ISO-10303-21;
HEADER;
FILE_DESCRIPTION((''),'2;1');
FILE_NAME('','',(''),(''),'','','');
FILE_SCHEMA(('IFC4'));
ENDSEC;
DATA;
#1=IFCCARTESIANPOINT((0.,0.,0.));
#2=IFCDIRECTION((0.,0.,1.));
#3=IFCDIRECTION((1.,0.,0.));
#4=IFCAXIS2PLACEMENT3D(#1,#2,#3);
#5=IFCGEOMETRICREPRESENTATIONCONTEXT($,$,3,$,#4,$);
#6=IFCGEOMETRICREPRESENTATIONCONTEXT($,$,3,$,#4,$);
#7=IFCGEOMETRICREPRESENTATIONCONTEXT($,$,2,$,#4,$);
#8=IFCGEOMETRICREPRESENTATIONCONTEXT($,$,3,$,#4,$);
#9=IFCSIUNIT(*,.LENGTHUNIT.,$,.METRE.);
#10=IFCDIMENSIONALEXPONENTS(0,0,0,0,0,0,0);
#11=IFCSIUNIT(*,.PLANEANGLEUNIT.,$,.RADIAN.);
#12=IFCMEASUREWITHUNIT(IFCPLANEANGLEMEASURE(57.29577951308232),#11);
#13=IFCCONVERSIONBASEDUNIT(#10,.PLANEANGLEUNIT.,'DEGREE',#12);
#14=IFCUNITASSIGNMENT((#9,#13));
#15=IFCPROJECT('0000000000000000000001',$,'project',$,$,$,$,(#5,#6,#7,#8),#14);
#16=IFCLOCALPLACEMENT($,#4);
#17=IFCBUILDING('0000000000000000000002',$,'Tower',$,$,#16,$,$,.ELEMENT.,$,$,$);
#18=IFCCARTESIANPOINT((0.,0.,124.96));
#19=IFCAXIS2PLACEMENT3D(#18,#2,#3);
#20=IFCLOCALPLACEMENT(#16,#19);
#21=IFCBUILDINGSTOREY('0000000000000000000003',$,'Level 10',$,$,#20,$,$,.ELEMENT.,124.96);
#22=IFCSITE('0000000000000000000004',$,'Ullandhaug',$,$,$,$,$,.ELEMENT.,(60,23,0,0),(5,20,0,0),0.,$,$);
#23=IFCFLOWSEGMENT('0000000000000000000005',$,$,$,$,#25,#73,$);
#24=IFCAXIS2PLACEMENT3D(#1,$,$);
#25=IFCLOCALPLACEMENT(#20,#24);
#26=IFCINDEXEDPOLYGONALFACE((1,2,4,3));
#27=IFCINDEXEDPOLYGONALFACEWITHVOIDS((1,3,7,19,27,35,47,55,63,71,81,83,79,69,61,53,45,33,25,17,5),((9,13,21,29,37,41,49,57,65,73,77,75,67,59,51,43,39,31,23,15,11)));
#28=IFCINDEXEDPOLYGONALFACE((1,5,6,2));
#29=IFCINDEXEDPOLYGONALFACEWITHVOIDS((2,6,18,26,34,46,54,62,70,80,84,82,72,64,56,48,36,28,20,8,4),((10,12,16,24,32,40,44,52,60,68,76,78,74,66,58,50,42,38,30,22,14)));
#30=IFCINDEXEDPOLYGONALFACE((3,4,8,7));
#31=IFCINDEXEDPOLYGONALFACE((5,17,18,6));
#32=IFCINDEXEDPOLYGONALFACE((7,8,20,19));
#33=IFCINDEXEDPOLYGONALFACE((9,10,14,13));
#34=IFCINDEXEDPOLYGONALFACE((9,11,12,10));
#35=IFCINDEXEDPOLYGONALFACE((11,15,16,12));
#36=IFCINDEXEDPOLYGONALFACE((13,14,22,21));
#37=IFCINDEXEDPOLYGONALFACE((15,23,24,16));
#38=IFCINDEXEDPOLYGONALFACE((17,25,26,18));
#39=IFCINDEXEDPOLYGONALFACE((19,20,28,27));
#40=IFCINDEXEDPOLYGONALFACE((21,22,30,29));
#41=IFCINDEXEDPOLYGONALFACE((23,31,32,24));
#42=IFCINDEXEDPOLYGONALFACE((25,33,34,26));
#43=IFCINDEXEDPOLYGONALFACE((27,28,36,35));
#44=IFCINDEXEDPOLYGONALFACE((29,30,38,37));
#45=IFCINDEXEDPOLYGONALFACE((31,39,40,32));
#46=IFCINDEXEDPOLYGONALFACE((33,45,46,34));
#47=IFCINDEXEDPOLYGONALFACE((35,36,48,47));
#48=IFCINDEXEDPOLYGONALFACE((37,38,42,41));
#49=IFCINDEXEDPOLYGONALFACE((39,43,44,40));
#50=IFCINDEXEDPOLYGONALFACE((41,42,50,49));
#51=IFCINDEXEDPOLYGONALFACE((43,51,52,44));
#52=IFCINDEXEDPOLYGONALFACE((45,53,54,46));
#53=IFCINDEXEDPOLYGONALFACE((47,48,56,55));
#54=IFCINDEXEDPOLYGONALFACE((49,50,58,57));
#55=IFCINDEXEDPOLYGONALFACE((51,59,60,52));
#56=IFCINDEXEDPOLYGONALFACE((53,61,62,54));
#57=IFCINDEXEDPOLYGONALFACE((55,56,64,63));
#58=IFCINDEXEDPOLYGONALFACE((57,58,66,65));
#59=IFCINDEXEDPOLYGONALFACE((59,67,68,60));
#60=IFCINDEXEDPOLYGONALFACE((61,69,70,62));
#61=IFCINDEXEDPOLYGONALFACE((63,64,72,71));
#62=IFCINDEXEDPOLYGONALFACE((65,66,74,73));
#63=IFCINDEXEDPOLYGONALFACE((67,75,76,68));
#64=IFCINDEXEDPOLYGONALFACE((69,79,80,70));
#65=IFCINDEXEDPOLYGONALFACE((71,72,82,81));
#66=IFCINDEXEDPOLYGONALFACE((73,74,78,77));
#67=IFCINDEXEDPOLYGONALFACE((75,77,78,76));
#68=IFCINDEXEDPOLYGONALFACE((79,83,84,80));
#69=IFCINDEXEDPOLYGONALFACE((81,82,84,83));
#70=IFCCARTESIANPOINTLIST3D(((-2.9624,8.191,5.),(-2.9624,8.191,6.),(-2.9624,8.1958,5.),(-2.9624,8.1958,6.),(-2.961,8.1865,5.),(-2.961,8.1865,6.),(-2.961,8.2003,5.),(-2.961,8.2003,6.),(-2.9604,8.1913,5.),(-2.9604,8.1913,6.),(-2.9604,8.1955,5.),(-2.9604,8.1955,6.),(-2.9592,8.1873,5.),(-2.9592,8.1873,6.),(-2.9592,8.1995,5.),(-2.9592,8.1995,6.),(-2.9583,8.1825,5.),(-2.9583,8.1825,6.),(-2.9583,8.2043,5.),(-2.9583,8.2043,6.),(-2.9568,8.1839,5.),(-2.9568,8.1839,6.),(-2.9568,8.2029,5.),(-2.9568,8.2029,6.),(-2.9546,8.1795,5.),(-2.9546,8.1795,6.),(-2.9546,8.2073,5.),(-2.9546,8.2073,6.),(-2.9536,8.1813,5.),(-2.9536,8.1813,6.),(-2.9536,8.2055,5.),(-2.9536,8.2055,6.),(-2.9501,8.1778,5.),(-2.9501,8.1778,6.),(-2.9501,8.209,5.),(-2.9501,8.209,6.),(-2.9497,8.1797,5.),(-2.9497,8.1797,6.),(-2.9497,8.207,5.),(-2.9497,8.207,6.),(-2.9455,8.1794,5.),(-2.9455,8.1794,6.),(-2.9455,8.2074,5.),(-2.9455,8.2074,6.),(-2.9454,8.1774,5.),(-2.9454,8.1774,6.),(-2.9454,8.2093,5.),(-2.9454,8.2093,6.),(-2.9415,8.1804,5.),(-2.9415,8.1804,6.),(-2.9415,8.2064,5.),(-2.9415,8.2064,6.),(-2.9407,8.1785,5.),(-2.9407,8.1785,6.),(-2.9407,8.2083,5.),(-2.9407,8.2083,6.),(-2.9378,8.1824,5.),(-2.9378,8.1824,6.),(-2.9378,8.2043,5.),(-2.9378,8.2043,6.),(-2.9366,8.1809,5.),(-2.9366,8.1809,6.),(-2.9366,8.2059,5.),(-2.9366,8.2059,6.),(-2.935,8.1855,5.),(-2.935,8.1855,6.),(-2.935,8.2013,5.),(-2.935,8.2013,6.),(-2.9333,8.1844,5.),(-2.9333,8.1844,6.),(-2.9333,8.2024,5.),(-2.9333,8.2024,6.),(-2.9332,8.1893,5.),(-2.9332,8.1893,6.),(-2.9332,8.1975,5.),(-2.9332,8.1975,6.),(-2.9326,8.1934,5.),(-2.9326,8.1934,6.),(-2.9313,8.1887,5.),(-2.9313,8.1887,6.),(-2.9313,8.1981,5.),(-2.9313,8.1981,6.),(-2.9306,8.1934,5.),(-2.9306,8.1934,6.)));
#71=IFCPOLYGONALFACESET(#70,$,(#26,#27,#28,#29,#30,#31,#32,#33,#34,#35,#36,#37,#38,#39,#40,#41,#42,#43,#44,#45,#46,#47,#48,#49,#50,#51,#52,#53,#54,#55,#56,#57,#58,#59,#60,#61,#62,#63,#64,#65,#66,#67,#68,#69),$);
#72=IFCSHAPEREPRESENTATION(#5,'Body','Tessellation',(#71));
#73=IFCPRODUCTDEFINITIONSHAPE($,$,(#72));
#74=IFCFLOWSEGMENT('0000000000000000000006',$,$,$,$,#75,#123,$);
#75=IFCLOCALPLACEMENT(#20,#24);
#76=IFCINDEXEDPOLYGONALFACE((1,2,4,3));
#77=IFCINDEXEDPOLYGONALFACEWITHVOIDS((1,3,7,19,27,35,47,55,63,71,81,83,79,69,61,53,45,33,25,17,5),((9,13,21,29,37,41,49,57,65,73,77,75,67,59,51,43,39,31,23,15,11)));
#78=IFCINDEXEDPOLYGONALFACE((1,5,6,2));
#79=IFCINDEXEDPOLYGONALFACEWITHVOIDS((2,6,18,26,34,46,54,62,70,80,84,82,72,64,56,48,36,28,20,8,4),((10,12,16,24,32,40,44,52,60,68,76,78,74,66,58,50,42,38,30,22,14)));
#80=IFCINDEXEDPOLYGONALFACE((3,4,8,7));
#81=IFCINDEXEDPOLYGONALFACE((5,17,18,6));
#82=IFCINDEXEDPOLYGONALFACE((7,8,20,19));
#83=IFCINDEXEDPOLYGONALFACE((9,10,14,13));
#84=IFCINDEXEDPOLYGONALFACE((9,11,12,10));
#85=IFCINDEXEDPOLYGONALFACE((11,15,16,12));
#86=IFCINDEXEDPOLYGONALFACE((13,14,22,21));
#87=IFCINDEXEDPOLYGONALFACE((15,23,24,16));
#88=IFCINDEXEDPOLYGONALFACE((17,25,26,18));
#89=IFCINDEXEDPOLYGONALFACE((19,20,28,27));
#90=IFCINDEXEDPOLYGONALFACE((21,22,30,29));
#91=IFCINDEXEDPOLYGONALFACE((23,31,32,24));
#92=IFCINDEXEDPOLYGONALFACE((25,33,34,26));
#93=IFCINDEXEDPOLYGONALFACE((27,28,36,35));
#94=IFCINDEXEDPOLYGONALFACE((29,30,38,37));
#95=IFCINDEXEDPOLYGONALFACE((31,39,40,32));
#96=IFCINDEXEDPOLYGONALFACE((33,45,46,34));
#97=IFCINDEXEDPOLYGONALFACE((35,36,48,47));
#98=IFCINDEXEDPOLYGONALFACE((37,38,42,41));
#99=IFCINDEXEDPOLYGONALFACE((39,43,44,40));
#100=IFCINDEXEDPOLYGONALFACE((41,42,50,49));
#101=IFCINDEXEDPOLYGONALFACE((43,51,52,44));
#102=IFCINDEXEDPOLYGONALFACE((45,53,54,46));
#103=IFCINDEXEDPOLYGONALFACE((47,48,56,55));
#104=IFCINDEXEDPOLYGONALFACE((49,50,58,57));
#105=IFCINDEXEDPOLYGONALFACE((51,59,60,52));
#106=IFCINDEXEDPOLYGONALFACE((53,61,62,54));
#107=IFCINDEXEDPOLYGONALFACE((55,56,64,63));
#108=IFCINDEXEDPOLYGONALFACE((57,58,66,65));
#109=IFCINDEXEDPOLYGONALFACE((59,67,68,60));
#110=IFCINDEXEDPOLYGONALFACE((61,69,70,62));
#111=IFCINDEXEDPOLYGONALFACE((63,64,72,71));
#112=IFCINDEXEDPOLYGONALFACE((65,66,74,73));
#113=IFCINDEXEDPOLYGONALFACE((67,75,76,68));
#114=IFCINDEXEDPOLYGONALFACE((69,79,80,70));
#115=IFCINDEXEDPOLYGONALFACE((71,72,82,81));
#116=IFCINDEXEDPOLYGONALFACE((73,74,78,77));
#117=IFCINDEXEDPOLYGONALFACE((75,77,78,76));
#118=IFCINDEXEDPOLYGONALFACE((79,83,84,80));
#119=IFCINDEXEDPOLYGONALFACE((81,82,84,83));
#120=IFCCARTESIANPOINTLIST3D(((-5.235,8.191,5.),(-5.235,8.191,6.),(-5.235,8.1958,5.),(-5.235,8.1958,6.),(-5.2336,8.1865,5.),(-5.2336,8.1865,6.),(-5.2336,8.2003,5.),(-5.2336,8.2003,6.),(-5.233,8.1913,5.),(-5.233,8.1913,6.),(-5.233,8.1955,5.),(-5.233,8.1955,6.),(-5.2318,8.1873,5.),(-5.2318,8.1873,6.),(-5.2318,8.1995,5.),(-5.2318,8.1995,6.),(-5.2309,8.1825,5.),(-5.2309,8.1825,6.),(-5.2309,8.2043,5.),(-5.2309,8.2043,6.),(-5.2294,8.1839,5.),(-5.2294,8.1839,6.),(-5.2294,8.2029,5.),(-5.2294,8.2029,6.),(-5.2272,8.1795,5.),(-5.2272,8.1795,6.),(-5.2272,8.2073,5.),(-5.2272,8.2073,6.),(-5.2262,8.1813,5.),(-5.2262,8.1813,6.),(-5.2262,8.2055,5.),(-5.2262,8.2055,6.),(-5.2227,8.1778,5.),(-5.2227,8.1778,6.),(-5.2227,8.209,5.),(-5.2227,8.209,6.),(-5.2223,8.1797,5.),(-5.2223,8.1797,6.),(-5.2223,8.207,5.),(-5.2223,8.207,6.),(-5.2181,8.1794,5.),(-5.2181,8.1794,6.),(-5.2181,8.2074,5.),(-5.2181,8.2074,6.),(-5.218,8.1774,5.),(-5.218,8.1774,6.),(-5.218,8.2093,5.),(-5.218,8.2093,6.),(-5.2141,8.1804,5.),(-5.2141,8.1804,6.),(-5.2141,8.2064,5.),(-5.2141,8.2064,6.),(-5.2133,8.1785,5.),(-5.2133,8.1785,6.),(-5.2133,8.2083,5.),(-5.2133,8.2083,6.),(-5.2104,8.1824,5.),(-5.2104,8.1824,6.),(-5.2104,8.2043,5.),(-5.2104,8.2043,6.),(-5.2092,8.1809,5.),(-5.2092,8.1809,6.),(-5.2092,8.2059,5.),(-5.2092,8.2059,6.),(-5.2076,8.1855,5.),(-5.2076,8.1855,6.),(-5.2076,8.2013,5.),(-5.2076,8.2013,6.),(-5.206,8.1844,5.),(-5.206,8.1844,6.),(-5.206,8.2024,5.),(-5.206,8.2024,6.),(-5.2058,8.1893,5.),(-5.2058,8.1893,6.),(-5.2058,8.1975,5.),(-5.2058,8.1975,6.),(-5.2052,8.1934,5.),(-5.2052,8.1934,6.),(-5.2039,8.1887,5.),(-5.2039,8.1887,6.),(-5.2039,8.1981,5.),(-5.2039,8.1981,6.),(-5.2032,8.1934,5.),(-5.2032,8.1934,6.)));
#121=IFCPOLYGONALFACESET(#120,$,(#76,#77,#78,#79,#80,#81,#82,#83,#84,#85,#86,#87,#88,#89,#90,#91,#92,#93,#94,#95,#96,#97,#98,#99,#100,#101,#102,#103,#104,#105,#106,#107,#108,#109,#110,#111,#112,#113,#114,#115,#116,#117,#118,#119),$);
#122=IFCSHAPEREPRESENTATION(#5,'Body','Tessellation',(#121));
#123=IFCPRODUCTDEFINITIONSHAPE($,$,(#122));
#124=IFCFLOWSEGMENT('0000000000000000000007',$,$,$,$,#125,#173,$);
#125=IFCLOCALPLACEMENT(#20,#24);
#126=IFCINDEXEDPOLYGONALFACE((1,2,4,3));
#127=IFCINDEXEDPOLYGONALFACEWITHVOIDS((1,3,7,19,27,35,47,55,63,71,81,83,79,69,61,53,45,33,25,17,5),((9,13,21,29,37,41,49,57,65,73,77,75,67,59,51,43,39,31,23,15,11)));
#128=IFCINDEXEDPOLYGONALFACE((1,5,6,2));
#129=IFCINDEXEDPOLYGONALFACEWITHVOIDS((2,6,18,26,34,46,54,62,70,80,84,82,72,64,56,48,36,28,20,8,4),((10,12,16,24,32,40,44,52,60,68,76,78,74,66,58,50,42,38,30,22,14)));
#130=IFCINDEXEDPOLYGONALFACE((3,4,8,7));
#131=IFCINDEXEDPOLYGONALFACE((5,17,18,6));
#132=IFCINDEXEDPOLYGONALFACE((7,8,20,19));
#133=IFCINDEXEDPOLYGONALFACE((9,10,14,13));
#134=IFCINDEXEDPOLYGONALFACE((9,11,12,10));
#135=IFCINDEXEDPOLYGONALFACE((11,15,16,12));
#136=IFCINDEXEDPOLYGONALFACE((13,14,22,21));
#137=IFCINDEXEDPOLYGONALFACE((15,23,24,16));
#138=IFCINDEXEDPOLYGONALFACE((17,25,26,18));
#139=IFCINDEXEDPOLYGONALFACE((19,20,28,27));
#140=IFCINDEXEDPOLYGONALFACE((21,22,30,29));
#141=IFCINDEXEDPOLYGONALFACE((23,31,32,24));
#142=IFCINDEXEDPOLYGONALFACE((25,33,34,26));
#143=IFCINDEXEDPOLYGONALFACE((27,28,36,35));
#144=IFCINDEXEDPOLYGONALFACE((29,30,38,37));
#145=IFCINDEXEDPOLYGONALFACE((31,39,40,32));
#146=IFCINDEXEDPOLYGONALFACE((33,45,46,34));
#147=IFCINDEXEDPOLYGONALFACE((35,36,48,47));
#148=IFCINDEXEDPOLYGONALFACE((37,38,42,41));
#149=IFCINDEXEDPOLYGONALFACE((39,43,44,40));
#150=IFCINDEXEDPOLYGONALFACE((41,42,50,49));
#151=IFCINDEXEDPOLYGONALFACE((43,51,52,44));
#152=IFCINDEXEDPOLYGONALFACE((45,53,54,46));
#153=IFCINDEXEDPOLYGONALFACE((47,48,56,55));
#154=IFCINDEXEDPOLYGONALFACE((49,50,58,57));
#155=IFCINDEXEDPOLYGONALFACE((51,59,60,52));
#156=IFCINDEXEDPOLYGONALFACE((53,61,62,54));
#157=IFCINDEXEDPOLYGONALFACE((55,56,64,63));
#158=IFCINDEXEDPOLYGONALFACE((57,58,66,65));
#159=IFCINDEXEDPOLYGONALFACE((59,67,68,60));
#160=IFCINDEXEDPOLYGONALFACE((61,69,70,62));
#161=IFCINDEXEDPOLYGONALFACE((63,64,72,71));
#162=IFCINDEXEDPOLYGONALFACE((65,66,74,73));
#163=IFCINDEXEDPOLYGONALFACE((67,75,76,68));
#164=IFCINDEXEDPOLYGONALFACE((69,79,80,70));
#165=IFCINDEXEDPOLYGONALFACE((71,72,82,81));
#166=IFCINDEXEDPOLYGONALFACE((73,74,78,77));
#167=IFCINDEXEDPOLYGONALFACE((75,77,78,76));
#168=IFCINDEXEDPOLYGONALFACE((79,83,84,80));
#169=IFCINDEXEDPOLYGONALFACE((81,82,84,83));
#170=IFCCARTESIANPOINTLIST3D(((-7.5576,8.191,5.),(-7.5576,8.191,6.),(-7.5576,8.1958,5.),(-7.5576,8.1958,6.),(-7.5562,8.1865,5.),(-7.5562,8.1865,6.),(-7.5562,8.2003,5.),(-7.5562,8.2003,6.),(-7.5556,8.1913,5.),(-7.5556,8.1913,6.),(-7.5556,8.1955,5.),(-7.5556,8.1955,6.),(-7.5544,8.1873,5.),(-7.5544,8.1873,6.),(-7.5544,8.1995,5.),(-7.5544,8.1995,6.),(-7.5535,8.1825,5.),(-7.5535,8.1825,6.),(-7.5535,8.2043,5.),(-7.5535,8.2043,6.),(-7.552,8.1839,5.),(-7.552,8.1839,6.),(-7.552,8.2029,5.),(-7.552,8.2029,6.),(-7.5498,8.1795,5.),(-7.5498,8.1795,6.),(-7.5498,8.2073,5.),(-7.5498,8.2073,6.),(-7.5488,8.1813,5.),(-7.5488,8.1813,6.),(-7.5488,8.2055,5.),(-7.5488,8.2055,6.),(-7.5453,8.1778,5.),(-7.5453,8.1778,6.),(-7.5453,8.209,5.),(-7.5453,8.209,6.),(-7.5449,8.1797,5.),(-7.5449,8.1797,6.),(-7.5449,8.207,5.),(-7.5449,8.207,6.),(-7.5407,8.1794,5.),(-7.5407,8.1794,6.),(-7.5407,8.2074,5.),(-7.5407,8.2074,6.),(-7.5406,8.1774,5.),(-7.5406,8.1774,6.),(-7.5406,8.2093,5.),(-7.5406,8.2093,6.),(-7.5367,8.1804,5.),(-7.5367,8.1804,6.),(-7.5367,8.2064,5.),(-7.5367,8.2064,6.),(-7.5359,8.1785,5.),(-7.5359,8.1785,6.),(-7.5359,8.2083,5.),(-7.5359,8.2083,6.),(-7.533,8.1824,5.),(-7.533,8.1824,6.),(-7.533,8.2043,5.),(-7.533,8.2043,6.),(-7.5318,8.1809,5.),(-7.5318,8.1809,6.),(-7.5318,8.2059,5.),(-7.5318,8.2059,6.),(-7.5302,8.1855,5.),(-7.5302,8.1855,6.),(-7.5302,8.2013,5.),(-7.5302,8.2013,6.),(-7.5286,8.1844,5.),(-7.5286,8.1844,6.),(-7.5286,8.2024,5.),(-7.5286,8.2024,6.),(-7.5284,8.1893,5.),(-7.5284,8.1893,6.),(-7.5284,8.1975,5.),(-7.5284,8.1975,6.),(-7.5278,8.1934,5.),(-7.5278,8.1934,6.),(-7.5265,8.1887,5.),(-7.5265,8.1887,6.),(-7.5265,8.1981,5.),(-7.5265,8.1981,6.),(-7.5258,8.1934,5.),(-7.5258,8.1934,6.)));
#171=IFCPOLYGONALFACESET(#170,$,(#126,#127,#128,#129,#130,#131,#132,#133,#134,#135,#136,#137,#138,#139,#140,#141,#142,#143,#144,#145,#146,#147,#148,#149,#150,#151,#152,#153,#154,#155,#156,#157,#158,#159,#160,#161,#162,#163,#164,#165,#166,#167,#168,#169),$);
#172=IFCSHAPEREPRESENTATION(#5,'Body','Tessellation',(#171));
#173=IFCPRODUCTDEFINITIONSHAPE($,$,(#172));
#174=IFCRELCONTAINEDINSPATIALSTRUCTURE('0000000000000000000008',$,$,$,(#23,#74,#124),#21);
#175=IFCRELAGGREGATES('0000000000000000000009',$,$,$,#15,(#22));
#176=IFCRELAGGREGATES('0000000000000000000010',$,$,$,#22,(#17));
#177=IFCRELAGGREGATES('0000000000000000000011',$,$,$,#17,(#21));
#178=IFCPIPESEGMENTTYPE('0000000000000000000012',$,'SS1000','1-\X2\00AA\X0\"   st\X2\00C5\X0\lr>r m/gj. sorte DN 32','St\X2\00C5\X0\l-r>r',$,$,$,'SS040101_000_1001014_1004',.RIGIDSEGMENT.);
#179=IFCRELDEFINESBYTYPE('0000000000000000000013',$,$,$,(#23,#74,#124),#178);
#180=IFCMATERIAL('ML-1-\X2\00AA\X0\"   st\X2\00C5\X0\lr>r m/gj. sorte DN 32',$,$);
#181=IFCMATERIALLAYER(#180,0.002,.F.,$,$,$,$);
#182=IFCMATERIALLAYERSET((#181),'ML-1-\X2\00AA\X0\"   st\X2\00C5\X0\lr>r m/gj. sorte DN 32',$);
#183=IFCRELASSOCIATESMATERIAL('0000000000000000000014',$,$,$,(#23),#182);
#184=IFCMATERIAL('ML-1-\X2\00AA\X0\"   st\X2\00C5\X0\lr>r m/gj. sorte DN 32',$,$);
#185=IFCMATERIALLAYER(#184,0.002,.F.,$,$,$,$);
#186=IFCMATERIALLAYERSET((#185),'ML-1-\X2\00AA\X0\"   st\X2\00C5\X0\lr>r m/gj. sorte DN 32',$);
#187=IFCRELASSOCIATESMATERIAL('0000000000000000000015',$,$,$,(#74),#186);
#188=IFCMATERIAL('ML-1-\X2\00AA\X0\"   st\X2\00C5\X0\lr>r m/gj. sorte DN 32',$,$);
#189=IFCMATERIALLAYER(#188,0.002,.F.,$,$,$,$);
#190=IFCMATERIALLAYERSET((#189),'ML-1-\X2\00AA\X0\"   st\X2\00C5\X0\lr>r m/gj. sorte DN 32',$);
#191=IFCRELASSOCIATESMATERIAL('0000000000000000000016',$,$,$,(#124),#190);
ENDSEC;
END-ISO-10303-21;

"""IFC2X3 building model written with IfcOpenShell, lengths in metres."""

from ifc_helpers import new_model, entity, si_unit, converted_unit, frame, origin_with_axes, origin_2d_with_axis, place, context, project, spatial, hollow_circle, extrude, material, layer, layer_set, layer_usage, type_object, element, save


model = new_model("IFC2X3")

# Units and contexts
context_of_model_1 = context(None, 3, world=origin_with_axes())
context_of_model_2 = context(None, 3, world=origin_with_axes())
context_of_model_3 = context(None, 2, world=origin_with_axes())
context_of_model_4 = context(None, 3, world=origin_with_axes())
ifc_project = project(units=[si_unit("LENGTHUNIT", "METRE"), converted_unit("PLANEANGLEUNIT", "DEGREE", entity("IfcPlaneAngleMeasure", 57.29577951308232), si_unit("PLANEANGLEUNIT", "RADIAN"), dimensions=[0, 0, 0, 0, 0, 0, 0])], contexts=[context_of_model_1, context_of_model_2, context_of_model_3, context_of_model_4])

# Site, building, storey
site = spatial("IfcSite", under=ifc_project, Name="Ullandhaug", CompositionType="ELEMENT", RefLatitude=(60, 23, 0, 0), RefLongitude=(5, 20, 0, 0), RefElevation=0.0)
building_placement = place(None, origin_with_axes())
building = spatial("IfcBuilding", under=site, at=building_placement, Name="Tower", CompositionType="ELEMENT")
storey_placement = place(building_placement, frame((0.0, 0.0, 124.96), z_axis=(0.0, 0.0, 1.0), x_axis=(1.0, 0.0, 0.0)))
storey = spatial("IfcBuildingStorey", under=building, at=storey_placement, Name="Level 10", CompositionType="ELEMENT", Elevation=124.96)

# Flow segments
ifc_material_1 = material(Name="ML-1-ª\"   stÅlr>r m/gj. sorte DN 32")
ifc_layer_1 = layer(ifc_material_1, 0.002, ventilated=False)
ifc_layer_set_1 = layer_set([ifc_layer_1], Name="ML-1-ª\"   stÅlr>r m/gj. sorte DN 32")
ifc_layer_usage_1 = layer_usage(ifc_layer_set_1, "AXIS2", "POSITIVE", 0.0)
pipe_segment_type_1 = type_object("IfcPipeSegmentType", Name="SS1000", Description="1-ª\"   stÅlr>r m/gj. sorte DN 32", ApplicableOccurrence="StÅl-r>r", ElementType="SS040101_000_1001014_1004", PredefinedType="RIGIDSEGMENT")
flow_segment_1_placement = place(storey_placement, frame((-2.9466, 8.1934, 5.0), z_axis=(0.0, 0.0, 1.0), x_axis=(1.0, 0.0, 0.0)))
element("IfcFlowSegment", 1, at=flow_segment_1_placement, inside=storey, type_object=pipe_segment_type_1, material=ifc_layer_usage_1, context=context_of_model_1, shape_type="SweptSolid", body=[
    extrude(hollow_circle(Radius=0.016, WallThickness=0.002, at=origin_2d_with_axis()), origin_with_axes(), (0.0, 0.0, 1.0), 1.0),
])
ifc_material_2 = material(Name="ML-1-ª\"   stÅlr>r m/gj. sorte DN 32")
ifc_layer_2 = layer(ifc_material_2, 0.002, ventilated=False)
ifc_layer_set_2 = layer_set([ifc_layer_2], Name="ML-1-ª\"   stÅlr>r m/gj. sorte DN 32")
ifc_layer_usage_2 = layer_usage(ifc_layer_set_2, "AXIS2", "POSITIVE", 0.0)
flow_segment_2_placement = place(storey_placement, frame((-5.2192, 8.1934, 5.0), z_axis=(0.0, 0.0, 1.0), x_axis=(1.0, 0.0, 0.0)))
element("IfcFlowSegment", 2, at=flow_segment_2_placement, inside=storey, type_object=pipe_segment_type_1, material=ifc_layer_usage_2, context=context_of_model_1, shape_type="SweptSolid", body=[
    extrude(hollow_circle(Radius=0.016, WallThickness=0.002, at=origin_2d_with_axis()), origin_with_axes(), (0.0, 0.0, 1.0), 1.0),
])
ifc_material_3 = material(Name="ML-1-ª\"   stÅlr>r m/gj. sorte DN 32")
ifc_layer_3 = layer(ifc_material_3, 0.002, ventilated=False)
ifc_layer_set_3 = layer_set([ifc_layer_3], Name="ML-1-ª\"   stÅlr>r m/gj. sorte DN 32")
ifc_layer_usage_3 = layer_usage(ifc_layer_set_3, "AXIS2", "POSITIVE", 0.0)
flow_segment_3_placement = place(storey_placement, frame((-7.5418, 8.1934, 5.0), z_axis=(0.0, 0.0, 1.0), x_axis=(1.0, 0.0, 0.0)))
element("IfcFlowSegment", 3, at=flow_segment_3_placement, inside=storey, type_object=pipe_segment_type_1, material=ifc_layer_usage_3, context=context_of_model_1, shape_type="SweptSolid", body=[
    extrude(hollow_circle(Radius=0.016, WallThickness=0.002, at=origin_2d_with_axis()), origin_with_axes(), (0.0, 0.0, 1.0), 1.0),
])

save(model, "model.ifc")
